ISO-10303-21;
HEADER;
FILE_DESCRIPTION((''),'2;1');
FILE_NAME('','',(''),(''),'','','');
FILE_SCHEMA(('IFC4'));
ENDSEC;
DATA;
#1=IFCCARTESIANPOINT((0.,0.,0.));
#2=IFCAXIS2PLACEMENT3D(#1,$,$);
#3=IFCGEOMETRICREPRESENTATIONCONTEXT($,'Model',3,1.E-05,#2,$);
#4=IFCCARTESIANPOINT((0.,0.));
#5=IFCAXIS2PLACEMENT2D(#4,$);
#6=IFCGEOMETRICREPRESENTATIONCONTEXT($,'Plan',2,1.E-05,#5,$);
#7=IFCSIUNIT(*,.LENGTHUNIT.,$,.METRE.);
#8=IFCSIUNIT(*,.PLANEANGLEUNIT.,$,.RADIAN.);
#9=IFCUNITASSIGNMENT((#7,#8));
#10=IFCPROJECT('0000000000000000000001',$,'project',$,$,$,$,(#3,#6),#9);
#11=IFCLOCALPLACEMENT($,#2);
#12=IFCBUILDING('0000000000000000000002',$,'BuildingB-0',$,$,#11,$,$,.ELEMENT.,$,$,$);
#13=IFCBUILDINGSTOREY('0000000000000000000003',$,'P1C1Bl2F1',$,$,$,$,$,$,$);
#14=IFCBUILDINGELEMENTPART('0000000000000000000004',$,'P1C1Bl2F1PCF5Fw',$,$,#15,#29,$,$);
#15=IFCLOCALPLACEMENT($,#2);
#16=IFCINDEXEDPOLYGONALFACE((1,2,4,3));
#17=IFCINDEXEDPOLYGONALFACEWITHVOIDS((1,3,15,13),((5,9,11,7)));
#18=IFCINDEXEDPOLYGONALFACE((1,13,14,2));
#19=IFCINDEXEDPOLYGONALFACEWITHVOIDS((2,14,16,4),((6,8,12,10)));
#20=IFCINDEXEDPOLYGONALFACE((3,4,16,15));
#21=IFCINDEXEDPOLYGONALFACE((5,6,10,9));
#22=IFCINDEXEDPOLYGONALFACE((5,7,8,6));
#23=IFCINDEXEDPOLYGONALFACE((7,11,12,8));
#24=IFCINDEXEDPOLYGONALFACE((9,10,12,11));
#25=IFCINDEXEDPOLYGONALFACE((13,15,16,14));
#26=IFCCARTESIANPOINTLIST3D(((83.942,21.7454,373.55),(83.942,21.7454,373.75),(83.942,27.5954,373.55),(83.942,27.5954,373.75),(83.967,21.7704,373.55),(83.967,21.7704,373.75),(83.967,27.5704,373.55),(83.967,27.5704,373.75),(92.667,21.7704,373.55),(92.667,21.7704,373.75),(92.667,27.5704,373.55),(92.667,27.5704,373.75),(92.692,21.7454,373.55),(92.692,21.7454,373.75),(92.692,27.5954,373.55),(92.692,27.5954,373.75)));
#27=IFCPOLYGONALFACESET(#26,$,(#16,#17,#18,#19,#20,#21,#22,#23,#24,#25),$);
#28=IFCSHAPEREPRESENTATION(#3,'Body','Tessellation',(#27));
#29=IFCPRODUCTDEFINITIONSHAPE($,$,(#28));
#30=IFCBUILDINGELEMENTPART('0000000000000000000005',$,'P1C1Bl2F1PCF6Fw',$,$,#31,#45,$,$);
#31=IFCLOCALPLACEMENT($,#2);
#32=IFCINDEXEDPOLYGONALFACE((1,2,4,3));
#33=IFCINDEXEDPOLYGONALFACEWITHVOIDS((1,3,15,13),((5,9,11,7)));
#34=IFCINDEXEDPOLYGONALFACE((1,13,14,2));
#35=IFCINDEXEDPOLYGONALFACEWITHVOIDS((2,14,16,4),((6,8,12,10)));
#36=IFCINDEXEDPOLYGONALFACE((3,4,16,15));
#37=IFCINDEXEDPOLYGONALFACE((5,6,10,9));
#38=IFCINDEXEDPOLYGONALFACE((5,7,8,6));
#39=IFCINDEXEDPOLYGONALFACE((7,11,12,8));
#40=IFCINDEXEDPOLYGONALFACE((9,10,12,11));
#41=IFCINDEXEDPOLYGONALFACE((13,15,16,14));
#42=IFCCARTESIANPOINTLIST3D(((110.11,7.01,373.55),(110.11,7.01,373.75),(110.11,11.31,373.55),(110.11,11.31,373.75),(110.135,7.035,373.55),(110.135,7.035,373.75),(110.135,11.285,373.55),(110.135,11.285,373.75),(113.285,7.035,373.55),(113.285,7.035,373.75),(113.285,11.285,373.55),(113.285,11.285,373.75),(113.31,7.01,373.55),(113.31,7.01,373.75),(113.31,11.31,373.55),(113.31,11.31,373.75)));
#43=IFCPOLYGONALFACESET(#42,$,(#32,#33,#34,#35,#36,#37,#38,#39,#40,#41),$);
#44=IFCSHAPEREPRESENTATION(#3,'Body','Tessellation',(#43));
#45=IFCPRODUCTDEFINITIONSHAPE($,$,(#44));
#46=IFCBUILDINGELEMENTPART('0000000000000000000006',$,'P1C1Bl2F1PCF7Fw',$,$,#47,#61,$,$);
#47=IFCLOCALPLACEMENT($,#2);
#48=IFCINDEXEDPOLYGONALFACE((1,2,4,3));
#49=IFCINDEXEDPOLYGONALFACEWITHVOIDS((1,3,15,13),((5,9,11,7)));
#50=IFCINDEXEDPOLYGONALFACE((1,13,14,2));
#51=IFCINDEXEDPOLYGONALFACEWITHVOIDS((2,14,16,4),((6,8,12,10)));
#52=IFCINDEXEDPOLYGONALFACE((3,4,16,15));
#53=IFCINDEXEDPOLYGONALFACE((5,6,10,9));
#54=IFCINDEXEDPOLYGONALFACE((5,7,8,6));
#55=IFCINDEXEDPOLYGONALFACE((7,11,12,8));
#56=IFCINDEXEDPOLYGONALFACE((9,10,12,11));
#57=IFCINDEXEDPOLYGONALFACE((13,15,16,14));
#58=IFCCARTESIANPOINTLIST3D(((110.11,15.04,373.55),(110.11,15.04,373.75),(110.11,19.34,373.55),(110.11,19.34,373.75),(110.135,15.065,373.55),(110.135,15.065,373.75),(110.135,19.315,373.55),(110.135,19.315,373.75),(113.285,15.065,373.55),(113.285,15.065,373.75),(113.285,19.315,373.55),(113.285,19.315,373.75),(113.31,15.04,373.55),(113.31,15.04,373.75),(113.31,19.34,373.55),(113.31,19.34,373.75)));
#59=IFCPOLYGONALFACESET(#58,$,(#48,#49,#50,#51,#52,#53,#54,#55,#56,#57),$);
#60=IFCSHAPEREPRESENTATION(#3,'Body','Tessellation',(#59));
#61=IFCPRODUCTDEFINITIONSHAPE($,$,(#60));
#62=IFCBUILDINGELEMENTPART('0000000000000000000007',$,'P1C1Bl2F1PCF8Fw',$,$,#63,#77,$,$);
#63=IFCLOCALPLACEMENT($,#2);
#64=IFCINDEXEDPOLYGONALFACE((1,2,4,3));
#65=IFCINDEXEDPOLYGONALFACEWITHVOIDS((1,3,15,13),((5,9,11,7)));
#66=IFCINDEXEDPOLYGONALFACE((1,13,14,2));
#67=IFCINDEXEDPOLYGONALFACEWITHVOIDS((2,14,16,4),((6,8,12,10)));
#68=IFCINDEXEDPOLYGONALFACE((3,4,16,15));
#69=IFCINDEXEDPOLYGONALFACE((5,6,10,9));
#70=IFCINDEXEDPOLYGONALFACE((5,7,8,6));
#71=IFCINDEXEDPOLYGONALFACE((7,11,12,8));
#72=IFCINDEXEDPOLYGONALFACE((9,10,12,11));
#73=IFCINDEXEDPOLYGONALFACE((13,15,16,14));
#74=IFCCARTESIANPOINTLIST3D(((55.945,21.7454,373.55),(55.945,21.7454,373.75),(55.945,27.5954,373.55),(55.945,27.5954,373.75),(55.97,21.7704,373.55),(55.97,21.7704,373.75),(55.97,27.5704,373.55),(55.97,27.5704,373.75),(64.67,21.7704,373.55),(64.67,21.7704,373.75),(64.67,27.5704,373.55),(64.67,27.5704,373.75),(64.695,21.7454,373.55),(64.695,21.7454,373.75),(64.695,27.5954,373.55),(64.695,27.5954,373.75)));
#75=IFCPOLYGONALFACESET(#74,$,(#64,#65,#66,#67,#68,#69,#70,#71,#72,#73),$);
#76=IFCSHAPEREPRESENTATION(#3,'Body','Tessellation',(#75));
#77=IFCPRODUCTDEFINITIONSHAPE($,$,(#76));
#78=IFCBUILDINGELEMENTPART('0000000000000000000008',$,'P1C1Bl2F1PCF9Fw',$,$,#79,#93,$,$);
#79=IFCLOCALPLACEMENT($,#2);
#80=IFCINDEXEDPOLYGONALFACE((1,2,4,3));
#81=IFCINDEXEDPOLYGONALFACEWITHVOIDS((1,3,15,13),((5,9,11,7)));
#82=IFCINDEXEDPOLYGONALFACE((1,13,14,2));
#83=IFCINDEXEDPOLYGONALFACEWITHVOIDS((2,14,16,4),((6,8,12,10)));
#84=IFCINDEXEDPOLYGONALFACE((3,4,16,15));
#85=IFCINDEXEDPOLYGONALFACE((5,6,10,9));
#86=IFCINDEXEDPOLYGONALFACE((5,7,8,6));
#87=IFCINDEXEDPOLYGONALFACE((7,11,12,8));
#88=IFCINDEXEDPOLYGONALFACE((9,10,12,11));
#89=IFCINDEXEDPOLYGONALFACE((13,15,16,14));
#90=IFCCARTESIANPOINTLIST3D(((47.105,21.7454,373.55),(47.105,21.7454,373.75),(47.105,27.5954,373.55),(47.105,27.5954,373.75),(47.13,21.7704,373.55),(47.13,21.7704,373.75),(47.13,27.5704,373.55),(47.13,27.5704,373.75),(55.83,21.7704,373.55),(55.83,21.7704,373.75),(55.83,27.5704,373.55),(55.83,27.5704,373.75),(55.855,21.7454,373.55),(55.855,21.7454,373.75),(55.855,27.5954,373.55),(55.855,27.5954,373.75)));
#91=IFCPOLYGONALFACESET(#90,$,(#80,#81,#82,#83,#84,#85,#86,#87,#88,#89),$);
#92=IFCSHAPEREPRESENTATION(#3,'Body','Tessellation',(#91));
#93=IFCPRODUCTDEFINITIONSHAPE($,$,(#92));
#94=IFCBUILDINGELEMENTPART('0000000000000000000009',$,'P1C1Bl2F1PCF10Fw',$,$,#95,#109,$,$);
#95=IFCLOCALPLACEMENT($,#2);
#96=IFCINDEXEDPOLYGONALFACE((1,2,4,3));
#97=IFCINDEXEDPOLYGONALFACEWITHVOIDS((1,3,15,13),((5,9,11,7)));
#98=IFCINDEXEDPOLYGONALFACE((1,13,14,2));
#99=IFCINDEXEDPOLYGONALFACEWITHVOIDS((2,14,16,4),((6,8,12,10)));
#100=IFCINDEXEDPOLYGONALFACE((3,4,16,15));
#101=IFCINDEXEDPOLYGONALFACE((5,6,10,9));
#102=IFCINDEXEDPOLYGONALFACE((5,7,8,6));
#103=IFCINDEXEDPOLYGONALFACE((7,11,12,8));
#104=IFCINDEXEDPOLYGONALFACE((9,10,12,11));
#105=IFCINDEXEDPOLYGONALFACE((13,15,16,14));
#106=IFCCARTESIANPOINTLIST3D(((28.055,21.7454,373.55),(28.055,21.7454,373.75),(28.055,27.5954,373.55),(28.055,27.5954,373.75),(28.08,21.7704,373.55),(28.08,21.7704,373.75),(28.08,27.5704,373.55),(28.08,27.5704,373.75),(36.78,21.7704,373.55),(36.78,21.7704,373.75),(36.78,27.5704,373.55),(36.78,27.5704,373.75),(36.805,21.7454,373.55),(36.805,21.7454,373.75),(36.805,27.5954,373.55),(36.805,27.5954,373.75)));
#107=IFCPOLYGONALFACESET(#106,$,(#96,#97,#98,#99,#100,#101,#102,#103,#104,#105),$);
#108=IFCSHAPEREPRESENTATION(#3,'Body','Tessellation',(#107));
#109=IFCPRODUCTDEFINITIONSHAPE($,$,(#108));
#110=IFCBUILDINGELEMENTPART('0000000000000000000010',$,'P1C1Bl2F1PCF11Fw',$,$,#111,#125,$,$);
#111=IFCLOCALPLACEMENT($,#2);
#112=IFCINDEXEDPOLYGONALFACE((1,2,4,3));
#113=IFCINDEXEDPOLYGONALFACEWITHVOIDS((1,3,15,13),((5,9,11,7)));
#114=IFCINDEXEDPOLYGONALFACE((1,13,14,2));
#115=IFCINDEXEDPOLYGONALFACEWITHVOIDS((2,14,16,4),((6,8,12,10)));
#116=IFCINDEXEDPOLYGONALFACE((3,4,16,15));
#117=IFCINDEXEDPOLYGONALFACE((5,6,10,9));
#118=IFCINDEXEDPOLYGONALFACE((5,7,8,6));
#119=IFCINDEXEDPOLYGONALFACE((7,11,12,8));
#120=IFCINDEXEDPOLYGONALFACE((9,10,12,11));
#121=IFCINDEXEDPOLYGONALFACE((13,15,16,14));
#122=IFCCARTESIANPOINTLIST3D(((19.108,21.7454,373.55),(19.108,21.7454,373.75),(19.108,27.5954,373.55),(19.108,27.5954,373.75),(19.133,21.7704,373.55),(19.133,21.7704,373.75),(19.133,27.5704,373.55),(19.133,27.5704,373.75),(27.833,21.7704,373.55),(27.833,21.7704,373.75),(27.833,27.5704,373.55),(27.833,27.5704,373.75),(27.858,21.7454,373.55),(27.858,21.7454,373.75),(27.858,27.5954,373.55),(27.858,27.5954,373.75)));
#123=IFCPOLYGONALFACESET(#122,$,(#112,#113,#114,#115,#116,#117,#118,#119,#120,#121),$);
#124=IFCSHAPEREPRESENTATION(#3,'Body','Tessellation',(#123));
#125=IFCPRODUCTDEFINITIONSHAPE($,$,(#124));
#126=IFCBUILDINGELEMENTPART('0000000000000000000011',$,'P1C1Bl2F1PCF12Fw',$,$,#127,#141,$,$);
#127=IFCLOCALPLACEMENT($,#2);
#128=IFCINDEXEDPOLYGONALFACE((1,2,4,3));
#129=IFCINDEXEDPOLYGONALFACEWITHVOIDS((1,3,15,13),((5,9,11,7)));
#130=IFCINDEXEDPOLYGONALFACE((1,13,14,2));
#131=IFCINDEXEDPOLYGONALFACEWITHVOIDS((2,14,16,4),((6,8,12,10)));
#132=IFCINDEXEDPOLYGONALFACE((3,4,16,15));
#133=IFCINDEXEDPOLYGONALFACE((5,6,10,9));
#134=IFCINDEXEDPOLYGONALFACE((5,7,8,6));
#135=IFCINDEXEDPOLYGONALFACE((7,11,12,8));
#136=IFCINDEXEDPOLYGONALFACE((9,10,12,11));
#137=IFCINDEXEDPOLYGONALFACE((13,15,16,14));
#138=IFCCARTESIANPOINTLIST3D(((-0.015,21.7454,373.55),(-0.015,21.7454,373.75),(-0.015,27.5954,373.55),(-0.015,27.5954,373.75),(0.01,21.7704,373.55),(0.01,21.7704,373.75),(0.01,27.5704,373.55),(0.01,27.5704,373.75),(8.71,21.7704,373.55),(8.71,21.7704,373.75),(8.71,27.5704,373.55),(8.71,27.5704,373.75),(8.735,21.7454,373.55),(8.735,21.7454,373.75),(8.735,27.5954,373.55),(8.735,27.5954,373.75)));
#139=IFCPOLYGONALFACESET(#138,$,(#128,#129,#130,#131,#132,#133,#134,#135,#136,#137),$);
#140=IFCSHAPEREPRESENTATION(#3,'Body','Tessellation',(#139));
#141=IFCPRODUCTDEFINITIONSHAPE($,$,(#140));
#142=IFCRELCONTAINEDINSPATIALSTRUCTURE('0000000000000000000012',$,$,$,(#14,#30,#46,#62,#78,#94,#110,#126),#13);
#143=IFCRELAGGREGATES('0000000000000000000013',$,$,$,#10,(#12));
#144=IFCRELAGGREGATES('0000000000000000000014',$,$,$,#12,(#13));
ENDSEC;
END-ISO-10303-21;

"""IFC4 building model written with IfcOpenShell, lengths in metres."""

from ifc_helpers import new_model, si_unit, origin, origin_2d, place, context, project, spatial, polyline, outline, extrude, element, save


model = new_model("IFC4")

# Units and contexts
model_context = context("Model", 3, precision=1e-05, world=origin())
plan_context = context("Plan", 2, precision=1e-05, world=origin_2d())
ifc_project = project(units=[si_unit("LENGTHUNIT", "METRE"), si_unit("PLANEANGLEUNIT", "RADIAN")], contexts=[model_context, plan_context])

# Building, storey
building_placement = place(None, origin())
building = spatial("IfcBuilding", under=ifc_project, at=building_placement, Name="BuildingB-0", CompositionType="ELEMENT")
storey = spatial("IfcBuildingStorey", under=building, Name="P1C1Bl2F1")

# Building element parts, openings
building_element_part_1 = element("IfcBuildingElementPart", 1, inside=storey, Name="P1C1Bl2F1PCF5Fw", context=model_context, shape_type="SweptSolid", body=[
    extrude(outline(polyline([(83.942, 21.7454, 373.55), (92.692, 21.7454, 373.55), (92.692, 27.5954, 373.55), (83.942, 27.5954, 373.55), (83.942, 21.7454, 373.55)])), None, (0.0, 0.0, 1.0), 0.2),
])
element("IfcOpeningElement", 2, inside=storey, cuts=building_element_part_1, context=model_context, shape_type="SweptSolid", body=[
    extrude(outline(polyline([(83.967, 21.7704, 373.55), (92.667, 21.7704, 373.55), (92.667, 27.5704, 373.55), (83.967, 27.5704, 373.55), (83.967, 21.7704, 373.55)])), None, (0.0, 0.0, 1.0), 0.2),
])
building_element_part_2 = element("IfcBuildingElementPart", 3, inside=storey, Name="P1C1Bl2F1PCF6Fw", context=model_context, shape_type="SweptSolid", body=[
    extrude(outline(polyline([(110.11, 11.31, 373.55), (113.31, 11.31, 373.55), (113.31, 7.01, 373.55), (110.11, 7.01, 373.55), (110.11, 11.31, 373.55)])), None, (0.0, 0.0, 1.0), 0.2),
])
element("IfcOpeningElement", 4, inside=storey, cuts=building_element_part_2, context=model_context, shape_type="SweptSolid", body=[
    extrude(outline(polyline([(110.135, 11.285, 373.55), (113.285, 11.285, 373.55), (113.285, 7.035, 373.55), (110.135, 7.035, 373.55), (110.135, 11.285, 373.55)])), None, (0.0, 0.0, 1.0), 0.2),
])
building_element_part_3 = element("IfcBuildingElementPart", 5, inside=storey, Name="P1C1Bl2F1PCF7Fw", context=model_context, shape_type="SweptSolid", body=[
    extrude(outline(polyline([(110.11, 19.34, 373.55), (113.31, 19.34, 373.55), (113.31, 15.04, 373.55), (110.11, 15.04, 373.55), (110.11, 19.34, 373.55)])), None, (0.0, 0.0, 1.0), 0.2),
])
element("IfcOpeningElement", 6, inside=storey, cuts=building_element_part_3, context=model_context, shape_type="SweptSolid", body=[
    extrude(outline(polyline([(110.135, 19.315, 373.55), (113.285, 19.315, 373.55), (113.285, 15.065, 373.55), (110.135, 15.065, 373.55), (110.135, 19.315, 373.55)])), None, (0.0, 0.0, 1.0), 0.2),
])
building_element_part_4 = element("IfcBuildingElementPart", 7, inside=storey, Name="P1C1Bl2F1PCF8Fw", context=model_context, shape_type="SweptSolid", body=[
    extrude(outline(polyline([(55.945, 27.5954, 373.55), (64.695, 27.5954, 373.55), (64.695, 21.7454, 373.55), (55.945, 21.7454, 373.55), (55.945, 27.5954, 373.55)])), None, (0.0, 0.0, 1.0), 0.2),
])
element("IfcOpeningElement", 8, inside=storey, cuts=building_element_part_4, context=model_context, shape_type="SweptSolid", body=[
    extrude(outline(polyline([(55.97, 27.5704, 373.55), (64.67, 27.5704, 373.55), (64.67, 21.7704, 373.55), (55.97, 21.7704, 373.55), (55.97, 27.5704, 373.55)])), None, (0.0, 0.0, 1.0), 0.2),
])
building_element_part_5 = element("IfcBuildingElementPart", 9, inside=storey, Name="P1C1Bl2F1PCF9Fw", context=model_context, shape_type="SweptSolid", body=[
    extrude(outline(polyline([(47.105, 21.7454, 373.55), (55.855, 21.7454, 373.55), (55.855, 27.5954, 373.55), (47.105, 27.5954, 373.55), (47.105, 21.7454, 373.55)])), None, (0.0, 0.0, 1.0), 0.2),
])
element("IfcOpeningElement", 10, inside=storey, cuts=building_element_part_5, context=model_context, shape_type="SweptSolid", body=[
    extrude(outline(polyline([(47.13, 21.7704, 373.55), (55.83, 21.7704, 373.55), (55.83, 27.5704, 373.55), (47.13, 27.5704, 373.55), (47.13, 21.7704, 373.55)])), None, (0.0, 0.0, 1.0), 0.2),
])
building_element_part_6 = element("IfcBuildingElementPart", 11, inside=storey, Name="P1C1Bl2F1PCF10Fw", context=model_context, shape_type="SweptSolid", body=[
    extrude(outline(polyline([(28.055, 21.7454, 373.55), (36.805, 21.7454, 373.55), (36.805, 27.5954, 373.55), (28.055, 27.5954, 373.55), (28.055, 21.7454, 373.55)])), None, (0.0, 0.0, 1.0), 0.2),
])
element("IfcOpeningElement", 12, inside=storey, cuts=building_element_part_6, context=model_context, shape_type="SweptSolid", body=[
    extrude(outline(polyline([(28.08, 21.7704, 373.55), (36.78, 21.7704, 373.55), (36.78, 27.5704, 373.55), (28.08, 27.5704, 373.55), (28.08, 21.7704, 373.55)])), None, (0.0, 0.0, 1.0), 0.2),
])
building_element_part_7 = element("IfcBuildingElementPart", 13, inside=storey, Name="P1C1Bl2F1PCF11Fw", context=model_context, shape_type="SweptSolid", body=[
    extrude(outline(polyline([(27.858, 27.5954, 373.55), (19.108, 27.5954, 373.55), (19.108, 21.7454, 373.55), (27.858, 21.7454, 373.55), (27.858, 27.5954, 373.55)])), None, (0.0, 0.0, 1.0), 0.2),
])
element("IfcOpeningElement", 14, inside=storey, cuts=building_element_part_7, context=model_context, shape_type="SweptSolid", body=[
    extrude(outline(polyline([(27.833, 27.5704, 373.55), (19.133, 27.5704, 373.55), (19.133, 21.7704, 373.55), (27.833, 21.7704, 373.55), (27.833, 27.5704, 373.55)])), None, (0.0, 0.0, 1.0), 0.2),
])
building_element_part_8 = element("IfcBuildingElementPart", 15, inside=storey, Name="P1C1Bl2F1PCF12Fw", context=model_context, shape_type="SweptSolid", body=[
    extrude(outline(polyline([(8.735, 27.5954, 373.55), (-0.015, 27.5954, 373.55), (-0.015, 21.7454, 373.55), (8.735, 21.7454, 373.55), (8.735, 27.5954, 373.55)])), None, (0.0, 0.0, 1.0), 0.2),
])
element("IfcOpeningElement", 16, inside=storey, cuts=building_element_part_8, context=model_context, shape_type="SweptSolid", body=[
    extrude(outline(polyline([(8.71, 27.5704, 373.55), (0.01, 27.5704, 373.55), (0.01, 21.7704, 373.55), (8.71, 21.7704, 373.55), (8.71, 27.5704, 373.55)])), None, (0.0, 0.0, 1.0), 0.2),
])

save(model, "model.ifc")
